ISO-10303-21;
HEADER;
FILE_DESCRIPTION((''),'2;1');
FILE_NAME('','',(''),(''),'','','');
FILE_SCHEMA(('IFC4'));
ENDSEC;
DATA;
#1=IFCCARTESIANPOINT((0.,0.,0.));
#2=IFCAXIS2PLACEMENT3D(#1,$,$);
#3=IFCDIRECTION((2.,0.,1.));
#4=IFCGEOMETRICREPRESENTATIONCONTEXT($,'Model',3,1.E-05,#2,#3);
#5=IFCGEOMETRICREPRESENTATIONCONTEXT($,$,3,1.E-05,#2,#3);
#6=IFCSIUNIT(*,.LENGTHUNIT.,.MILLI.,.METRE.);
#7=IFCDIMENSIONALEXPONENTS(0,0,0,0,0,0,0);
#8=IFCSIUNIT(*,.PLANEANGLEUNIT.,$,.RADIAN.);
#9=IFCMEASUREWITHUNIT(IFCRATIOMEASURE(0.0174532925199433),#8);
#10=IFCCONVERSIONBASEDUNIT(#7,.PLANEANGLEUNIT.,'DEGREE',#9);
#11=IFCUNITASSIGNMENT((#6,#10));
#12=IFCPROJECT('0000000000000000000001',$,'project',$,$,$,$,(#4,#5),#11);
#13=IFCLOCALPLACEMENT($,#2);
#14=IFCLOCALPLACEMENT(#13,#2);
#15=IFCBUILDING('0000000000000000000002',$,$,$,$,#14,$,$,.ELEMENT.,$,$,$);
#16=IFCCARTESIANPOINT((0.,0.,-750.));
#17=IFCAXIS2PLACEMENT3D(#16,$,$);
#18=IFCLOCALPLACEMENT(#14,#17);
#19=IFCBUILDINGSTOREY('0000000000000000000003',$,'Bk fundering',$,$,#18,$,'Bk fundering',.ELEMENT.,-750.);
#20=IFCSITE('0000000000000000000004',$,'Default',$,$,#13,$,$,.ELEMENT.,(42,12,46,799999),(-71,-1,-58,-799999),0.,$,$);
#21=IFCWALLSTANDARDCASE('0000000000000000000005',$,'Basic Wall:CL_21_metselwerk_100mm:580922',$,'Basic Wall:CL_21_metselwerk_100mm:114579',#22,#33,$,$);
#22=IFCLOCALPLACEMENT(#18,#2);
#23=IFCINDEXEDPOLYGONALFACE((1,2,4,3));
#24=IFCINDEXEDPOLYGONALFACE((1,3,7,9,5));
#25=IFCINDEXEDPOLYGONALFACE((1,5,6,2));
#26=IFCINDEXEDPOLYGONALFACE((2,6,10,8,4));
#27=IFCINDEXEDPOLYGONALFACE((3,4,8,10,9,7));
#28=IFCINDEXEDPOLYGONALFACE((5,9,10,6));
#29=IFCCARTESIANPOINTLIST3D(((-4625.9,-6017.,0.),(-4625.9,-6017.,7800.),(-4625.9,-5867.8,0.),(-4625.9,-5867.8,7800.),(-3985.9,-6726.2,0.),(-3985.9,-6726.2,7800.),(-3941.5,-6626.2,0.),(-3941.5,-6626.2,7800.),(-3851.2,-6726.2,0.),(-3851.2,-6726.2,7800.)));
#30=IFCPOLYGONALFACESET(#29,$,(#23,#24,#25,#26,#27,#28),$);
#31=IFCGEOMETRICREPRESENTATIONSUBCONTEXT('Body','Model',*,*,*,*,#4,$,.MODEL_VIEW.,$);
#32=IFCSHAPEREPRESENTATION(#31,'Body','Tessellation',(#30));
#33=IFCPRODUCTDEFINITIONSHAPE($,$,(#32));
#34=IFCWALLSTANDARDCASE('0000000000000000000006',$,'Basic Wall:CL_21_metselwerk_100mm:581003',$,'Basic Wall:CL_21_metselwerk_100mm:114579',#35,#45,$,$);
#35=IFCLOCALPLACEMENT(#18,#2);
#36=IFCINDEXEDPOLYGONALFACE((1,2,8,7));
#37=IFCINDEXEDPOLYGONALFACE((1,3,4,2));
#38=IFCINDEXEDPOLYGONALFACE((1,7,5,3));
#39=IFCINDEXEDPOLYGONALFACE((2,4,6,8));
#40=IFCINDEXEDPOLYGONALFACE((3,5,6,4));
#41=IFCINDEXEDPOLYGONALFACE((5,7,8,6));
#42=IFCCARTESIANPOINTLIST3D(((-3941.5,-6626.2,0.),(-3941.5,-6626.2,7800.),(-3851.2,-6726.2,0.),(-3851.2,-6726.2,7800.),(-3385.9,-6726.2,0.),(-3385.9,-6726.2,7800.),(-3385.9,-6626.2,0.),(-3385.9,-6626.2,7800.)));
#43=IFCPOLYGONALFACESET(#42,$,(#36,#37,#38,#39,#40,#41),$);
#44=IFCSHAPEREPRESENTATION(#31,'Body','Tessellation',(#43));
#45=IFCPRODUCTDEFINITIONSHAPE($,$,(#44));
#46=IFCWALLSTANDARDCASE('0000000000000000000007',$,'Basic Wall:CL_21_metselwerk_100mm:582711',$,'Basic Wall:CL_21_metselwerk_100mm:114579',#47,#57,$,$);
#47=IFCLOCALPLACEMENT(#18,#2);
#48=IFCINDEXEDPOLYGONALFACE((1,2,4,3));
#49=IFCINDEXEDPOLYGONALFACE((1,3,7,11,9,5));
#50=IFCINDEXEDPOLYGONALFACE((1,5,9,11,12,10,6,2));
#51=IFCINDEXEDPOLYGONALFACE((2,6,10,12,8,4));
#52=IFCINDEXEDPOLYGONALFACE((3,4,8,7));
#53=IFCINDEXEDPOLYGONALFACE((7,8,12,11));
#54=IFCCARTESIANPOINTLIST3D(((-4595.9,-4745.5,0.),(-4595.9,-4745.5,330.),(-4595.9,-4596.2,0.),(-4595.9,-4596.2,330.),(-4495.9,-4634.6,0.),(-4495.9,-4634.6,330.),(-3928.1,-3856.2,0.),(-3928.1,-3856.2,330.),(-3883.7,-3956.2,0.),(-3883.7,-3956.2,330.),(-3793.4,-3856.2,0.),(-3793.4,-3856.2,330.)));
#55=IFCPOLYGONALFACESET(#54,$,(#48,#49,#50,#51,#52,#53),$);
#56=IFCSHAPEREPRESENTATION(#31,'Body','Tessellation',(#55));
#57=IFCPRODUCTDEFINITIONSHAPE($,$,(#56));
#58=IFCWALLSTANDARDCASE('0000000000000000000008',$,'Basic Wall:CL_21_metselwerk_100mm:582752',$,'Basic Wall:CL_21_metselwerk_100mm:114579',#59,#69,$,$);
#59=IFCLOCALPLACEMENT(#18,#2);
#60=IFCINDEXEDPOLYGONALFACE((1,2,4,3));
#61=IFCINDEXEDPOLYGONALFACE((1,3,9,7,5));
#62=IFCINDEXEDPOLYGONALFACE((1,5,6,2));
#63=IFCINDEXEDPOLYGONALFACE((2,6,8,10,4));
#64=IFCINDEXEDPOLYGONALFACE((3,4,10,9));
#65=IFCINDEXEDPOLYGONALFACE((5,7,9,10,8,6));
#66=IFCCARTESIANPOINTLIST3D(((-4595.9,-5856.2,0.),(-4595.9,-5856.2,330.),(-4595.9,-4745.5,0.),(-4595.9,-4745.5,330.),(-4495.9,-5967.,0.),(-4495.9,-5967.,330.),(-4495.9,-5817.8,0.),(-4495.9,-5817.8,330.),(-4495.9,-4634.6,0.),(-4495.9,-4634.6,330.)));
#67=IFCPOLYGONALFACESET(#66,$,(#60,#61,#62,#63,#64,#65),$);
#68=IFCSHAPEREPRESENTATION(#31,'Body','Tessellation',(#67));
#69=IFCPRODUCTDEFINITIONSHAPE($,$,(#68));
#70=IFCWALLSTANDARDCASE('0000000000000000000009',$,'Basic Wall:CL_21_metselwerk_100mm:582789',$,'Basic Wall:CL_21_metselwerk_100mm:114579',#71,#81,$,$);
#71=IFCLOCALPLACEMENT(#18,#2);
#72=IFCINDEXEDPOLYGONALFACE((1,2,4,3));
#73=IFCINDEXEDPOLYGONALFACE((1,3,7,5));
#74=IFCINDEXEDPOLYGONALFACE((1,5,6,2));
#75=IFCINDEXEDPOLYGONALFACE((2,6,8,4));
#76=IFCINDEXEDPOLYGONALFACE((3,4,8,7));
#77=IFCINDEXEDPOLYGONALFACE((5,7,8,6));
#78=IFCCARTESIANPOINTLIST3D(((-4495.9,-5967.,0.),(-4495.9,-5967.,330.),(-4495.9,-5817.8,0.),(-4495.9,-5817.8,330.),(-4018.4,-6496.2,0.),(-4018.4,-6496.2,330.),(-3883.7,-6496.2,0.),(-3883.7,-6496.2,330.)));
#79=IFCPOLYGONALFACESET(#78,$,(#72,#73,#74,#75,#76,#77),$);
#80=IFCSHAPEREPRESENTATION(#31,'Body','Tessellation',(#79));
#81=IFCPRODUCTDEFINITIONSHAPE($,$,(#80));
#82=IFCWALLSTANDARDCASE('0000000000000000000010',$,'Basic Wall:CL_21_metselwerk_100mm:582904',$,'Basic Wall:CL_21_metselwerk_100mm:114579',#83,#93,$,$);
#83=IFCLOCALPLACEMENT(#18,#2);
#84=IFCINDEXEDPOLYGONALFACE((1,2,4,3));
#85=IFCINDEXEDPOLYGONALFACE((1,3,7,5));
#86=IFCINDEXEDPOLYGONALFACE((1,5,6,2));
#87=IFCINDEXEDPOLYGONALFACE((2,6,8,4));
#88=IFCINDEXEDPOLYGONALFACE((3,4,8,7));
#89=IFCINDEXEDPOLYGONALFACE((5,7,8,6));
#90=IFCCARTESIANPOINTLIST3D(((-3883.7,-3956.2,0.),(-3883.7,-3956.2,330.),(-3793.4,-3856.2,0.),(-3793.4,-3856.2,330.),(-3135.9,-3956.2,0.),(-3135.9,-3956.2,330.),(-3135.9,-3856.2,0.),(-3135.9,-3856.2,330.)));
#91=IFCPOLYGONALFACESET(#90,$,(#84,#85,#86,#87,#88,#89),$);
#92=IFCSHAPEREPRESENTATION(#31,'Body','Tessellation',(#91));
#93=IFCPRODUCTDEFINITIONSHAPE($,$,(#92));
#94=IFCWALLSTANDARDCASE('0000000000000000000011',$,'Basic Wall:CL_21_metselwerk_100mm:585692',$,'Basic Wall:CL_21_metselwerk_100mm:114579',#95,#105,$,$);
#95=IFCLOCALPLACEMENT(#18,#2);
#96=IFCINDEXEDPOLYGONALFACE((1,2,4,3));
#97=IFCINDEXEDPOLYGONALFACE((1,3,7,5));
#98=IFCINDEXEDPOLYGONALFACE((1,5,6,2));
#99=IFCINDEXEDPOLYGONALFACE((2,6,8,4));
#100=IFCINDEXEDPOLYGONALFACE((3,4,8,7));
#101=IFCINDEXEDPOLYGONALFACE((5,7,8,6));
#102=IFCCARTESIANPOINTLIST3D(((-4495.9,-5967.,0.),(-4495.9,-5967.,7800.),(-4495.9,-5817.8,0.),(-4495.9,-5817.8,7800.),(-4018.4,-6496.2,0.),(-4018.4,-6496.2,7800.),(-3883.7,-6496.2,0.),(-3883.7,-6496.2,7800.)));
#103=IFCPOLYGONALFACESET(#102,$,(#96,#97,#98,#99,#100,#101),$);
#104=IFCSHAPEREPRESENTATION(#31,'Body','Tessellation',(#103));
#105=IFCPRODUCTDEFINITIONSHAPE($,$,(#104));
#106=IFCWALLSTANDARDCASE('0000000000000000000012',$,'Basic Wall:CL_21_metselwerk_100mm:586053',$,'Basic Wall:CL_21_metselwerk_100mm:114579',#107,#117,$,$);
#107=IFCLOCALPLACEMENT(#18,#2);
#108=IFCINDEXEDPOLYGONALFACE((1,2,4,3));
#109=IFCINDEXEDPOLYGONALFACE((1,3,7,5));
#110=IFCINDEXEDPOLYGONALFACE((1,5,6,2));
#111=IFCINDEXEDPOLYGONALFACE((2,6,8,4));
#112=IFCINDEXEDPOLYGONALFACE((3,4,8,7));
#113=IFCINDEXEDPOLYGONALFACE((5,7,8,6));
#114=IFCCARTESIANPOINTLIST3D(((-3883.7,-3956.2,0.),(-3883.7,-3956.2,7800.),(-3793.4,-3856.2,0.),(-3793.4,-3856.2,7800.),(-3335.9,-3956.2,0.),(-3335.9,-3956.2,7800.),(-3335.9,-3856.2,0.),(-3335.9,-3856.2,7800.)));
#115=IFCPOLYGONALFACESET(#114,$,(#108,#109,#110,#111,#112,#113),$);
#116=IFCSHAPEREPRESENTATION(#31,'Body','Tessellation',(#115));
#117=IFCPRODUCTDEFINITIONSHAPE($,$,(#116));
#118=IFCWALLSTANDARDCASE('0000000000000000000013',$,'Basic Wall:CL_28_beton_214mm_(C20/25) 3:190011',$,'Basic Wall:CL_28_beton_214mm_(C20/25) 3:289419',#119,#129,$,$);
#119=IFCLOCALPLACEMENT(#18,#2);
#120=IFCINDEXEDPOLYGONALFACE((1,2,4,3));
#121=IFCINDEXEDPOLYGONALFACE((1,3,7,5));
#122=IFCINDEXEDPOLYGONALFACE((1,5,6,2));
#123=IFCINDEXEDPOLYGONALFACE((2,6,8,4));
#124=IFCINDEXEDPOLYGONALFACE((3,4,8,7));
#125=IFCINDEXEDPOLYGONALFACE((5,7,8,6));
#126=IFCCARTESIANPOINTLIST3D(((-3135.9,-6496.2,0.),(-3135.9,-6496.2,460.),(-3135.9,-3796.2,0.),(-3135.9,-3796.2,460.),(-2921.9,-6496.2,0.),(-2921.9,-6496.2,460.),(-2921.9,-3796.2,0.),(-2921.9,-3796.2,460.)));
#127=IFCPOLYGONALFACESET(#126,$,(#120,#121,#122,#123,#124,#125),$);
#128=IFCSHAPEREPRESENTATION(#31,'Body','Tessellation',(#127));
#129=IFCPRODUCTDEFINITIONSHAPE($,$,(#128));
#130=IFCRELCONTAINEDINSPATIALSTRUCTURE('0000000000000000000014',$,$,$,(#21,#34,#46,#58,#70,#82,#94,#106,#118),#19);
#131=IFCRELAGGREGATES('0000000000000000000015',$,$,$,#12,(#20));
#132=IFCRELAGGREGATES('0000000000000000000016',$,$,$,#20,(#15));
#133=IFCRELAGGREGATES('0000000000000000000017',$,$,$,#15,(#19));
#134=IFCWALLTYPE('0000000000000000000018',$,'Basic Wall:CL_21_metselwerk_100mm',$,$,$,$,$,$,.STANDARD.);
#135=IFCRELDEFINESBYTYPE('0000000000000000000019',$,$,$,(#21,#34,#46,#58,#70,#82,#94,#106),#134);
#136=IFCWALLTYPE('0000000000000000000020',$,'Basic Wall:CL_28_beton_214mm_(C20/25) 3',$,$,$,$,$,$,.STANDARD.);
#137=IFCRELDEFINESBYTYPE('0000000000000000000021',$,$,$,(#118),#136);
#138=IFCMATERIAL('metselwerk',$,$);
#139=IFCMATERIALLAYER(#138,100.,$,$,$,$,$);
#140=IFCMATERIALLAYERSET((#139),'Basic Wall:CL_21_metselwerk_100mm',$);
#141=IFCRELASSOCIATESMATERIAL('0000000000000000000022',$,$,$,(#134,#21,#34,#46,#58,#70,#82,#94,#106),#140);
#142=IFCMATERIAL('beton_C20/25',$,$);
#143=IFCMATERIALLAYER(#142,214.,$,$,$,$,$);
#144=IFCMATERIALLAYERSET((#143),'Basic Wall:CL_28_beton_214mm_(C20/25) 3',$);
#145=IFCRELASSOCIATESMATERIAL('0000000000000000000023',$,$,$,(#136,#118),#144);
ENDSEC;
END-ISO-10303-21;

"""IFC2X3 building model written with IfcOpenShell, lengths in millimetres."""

from ifc_helpers import new_model, entity, si_unit, converted_unit, direction, frame, frame_2d, origin, place, context, subcontext, project, spatial, polyline, rectangle, outline, extrude, clip, bounded_halfspace, material, layer, layer_set, layer_usage, type_object, element, save


model = new_model("IFC2X3")

# Units and contexts
model_context = context("Model", 3, precision=1e-05, world=origin(), true_north=direction((2.0, 0.0, 1.0)))
context_of_model = context(None, 3, precision=1e-05, world=origin(), true_north=direction((2.0, 0.0, 1.0)))
body_context = subcontext(model_context, "Body", "Model", "MODEL_VIEW")
ifc_project = project(units=[si_unit("LENGTHUNIT", "METRE", prefix="MILLI"), converted_unit("PLANEANGLEUNIT", "DEGREE", entity("IfcRatioMeasure", 0.0174532925199433), si_unit("PLANEANGLEUNIT", "RADIAN"), dimensions=[0, 0, 0, 0, 0, 0, 0])], contexts=[model_context, context_of_model])

# Site, building, storey
site_placement = place(None, origin())
site = spatial("IfcSite", under=ifc_project, at=site_placement, Name="Default", CompositionType="ELEMENT", RefLatitude=(42, 12, 46, 799999), RefLongitude=(-71, -1, -58, -799999), RefElevation=0.0)
building_placement = place(site_placement, origin())
building = spatial("IfcBuilding", under=site, at=building_placement, CompositionType="ELEMENT")
storey_placement = place(building_placement, frame((0.0, 0.0, -750.0)))
storey = spatial("IfcBuildingStorey", under=building, at=storey_placement, Name="Bk fundering", LongName="Bk fundering", CompositionType="ELEMENT", Elevation=-750.0)

# Walls
ifc_material_1 = material(Name="metselwerk")
ifc_layer_1 = layer(ifc_material_1, 100.0)
ifc_layer_set_1 = layer_set([ifc_layer_1], Name="Basic Wall:CL_21_metselwerk_100mm")
wall_type_1 = type_object("IfcWallType", Name="Basic Wall:CL_21_metselwerk_100mm", PredefinedType="STANDARD", material=ifc_layer_set_1)
ifc_layer_usage_1 = layer_usage(ifc_layer_set_1, "AXIS2", "NEGATIVE", 50.0)
wall_1_placement = place(storey_placement, frame((-4663.0, -5901.2, 0.0), z_axis=(0.0, 0.0, 1.0), x_axis=(0.669965, -0.742393, 0.0)))
element("IfcWallStandardCase", 1, at=wall_1_placement, inside=storey, type_object=wall_type_1, material=ifc_layer_usage_1, Name="Basic Wall:CL_21_metselwerk_100mm:580922", ObjectType="Basic Wall:CL_21_metselwerk_100mm:114579", context=body_context, shape_type="SweptSolid", body=[
    extrude(outline(polyline([(1066.1, -50.0), (1156.3, 50.0), (1021.6, 50.0), (0.0, 50.0), (110.8, -50.0), (1066.1, -50.0)])), origin(), (0.0, 0.0, 1.0), 7800.0),
])
ifc_layer_usage_2 = layer_usage(ifc_layer_set_1, "AXIS2", "POSITIVE", -50.0)
wall_2_placement = place(storey_placement, frame((-3941.5, -6676.2, 0.0)))
element("IfcWallStandardCase", 2, at=wall_2_placement, inside=storey, type_object=wall_type_1, material=ifc_layer_usage_2, Name="Basic Wall:CL_21_metselwerk_100mm:581003", ObjectType="Basic Wall:CL_21_metselwerk_100mm:114579", context=body_context, shape_type="SweptSolid", body=[
    extrude(outline(polyline([(555.6, -50.0), (555.6, 50.0), (0.0, 50.0), (90.2, -50.0), (555.6, -50.0)])), origin(), (0.0, 0.0, 1.0), 7800.0),
])
ifc_layer_usage_3 = layer_usage(ifc_layer_set_1, "AXIS2", "NEGATIVE", 50.0)
wall_3_placement = place(storey_placement, frame((-3830.5, -3822.7, 0.0), z_axis=(0.0, 0.0, 1.0), x_axis=(-0.669965, -0.742393, 0.0)))
element("IfcWallStandardCase", 3, at=wall_3_placement, inside=storey, type_object=wall_type_1, material=ifc_layer_usage_3, Name="Basic Wall:CL_21_metselwerk_100mm:582711", ObjectType="Basic Wall:CL_21_metselwerk_100mm:114579", context=body_context, shape_type="SweptSolid", body=[
    extrude(outline(polyline([(1087.0, -50.0), (1197.8, 50.0), (1048.6, 50.0), (134.7, 50.0), (0.0, 50.0), (90.2, -50.0), (1087.0, -50.0)])), origin(), (0.0, 0.0, 1.0), 330.0),
])
ifc_layer_usage_4 = layer_usage(ifc_layer_set_1, "AXIS2", "NEGATIVE", 50.0)
wall_4_placement = place(storey_placement, frame((-4545.9, -4634.6, 0.0), z_axis=(0.0, 0.0, 1.0), x_axis=(0.0, -1.0, 0.0)))
element("IfcWallStandardCase", 4, at=wall_4_placement, inside=storey, type_object=wall_type_1, material=ifc_layer_usage_4, Name="Basic Wall:CL_21_metselwerk_100mm:582752", ObjectType="Basic Wall:CL_21_metselwerk_100mm:114579", context=body_context, shape_type="SweptSolid", body=[
    extrude(outline(polyline([(1221.6, -50.0), (1332.4, 50.0), (1183.1, 50.0), (0.0, 50.0), (110.8, -50.0), (1221.6, -50.0)])), origin(), (0.0, 0.0, 1.0), 330.0),
])
ifc_layer_usage_5 = layer_usage(ifc_layer_set_1, "AXIS2", "NEGATIVE", 50.0)
wall_5_placement = place(storey_placement, frame((-4533.0, -5851.3, 0.0), z_axis=(0.0, 0.0, 1.0), x_axis=(0.669965, -0.742393, 0.0)))
element("IfcWallStandardCase", 5, at=wall_5_placement, inside=storey, type_object=wall_type_1, material=ifc_layer_usage_5, Name="Basic Wall:CL_21_metselwerk_100mm:582789", ObjectType="Basic Wall:CL_21_metselwerk_100mm:114579", context=body_context, shape_type="SweptSolid", body=[
    extrude(outline(polyline([(823.6, -50.0), (913.9, 50.0), (0.0, 50.0), (110.8, -50.0), (823.6, -50.0)])), origin(), (0.0, 0.0, 1.0), 330.0),
])
ifc_layer_usage_6 = layer_usage(ifc_layer_set_1, "AXIS2", "NEGATIVE", 50.0)
wall_6_placement = place(storey_placement, frame((-3135.9, -3906.2, 0.0), z_axis=(0.0, 0.0, 1.0), x_axis=(-1.0, 0.0, 0.0)))
element("IfcWallStandardCase", 6, at=wall_6_placement, inside=storey, type_object=wall_type_1, material=ifc_layer_usage_6, Name="Basic Wall:CL_21_metselwerk_100mm:582904", ObjectType="Basic Wall:CL_21_metselwerk_100mm:114579", context=body_context, shape_type="SweptSolid", body=[
    extrude(outline(polyline([(657.5, -50.0), (747.8, 50.0), (0.0, 50.0), (0.0, -50.0), (657.5, -50.0)])), origin(), (0.0, 0.0, 1.0), 330.0),
])

# Wall
ifc_layer_usage_7 = layer_usage(ifc_layer_set_1, "AXIS2", "NEGATIVE", 50.0)
wall_7_placement = place(storey_placement, frame((-4533.0, -5851.3, 0.0), z_axis=(0.0, 0.0, 1.0), x_axis=(0.669965, -0.742393, 0.0)))
element("IfcWallStandardCase", 7, at=wall_7_placement, inside=storey, type_object=wall_type_1, material=ifc_layer_usage_7, Name="Basic Wall:CL_21_metselwerk_100mm:585692", ObjectType="Basic Wall:CL_21_metselwerk_100mm:114579", context=body_context, shape_type="SweptSolid", body=[
    extrude(outline(polyline([(823.6, -50.0), (913.9, 50.0), (0.0, 50.0), (110.8, -50.0), (823.6, -50.0)])), origin(), (0.0, 0.0, 1.0), 7800.0),
])

# Walls
ifc_layer_usage_8 = layer_usage(ifc_layer_set_1, "AXIS2", "NEGATIVE", 50.0)
wall_8_placement = place(storey_placement, frame((-3335.9, -3906.2, 0.0), z_axis=(0.0, 0.0, 1.0), x_axis=(-1.0, 0.0, 0.0)))
element("IfcWallStandardCase", 8, at=wall_8_placement, inside=storey, type_object=wall_type_1, material=ifc_layer_usage_8, Name="Basic Wall:CL_21_metselwerk_100mm:586053", ObjectType="Basic Wall:CL_21_metselwerk_100mm:114579", context=body_context, shape_type="SweptSolid", body=[
    extrude(outline(polyline([(457.5, -50.0), (547.8, 50.0), (0.0, 50.0), (0.0, -50.0), (457.5, -50.0)])), origin(), (0.0, 0.0, 1.0), 7800.0),
])
ifc_material_2 = material(Name="beton_C20/25")
ifc_layer_2 = layer(ifc_material_2, 214.0)
ifc_layer_set_2 = layer_set([ifc_layer_2], Name="Basic Wall:CL_28_beton_214mm_(C20/25) 3")
ifc_layer_usage_9 = layer_usage(ifc_layer_set_2, "AXIS2", "NEGATIVE", 107.0)
wall_type_2 = type_object("IfcWallType", Name="Basic Wall:CL_28_beton_214mm_(C20/25) 3", PredefinedType="STANDARD", material=ifc_layer_set_2)
wall_9_placement = place(storey_placement, frame((-3028.9, -3796.2, 0.0), z_axis=(0.0, 0.0, 1.0), x_axis=(0.0, -1.0, 0.0)))
element("IfcWallStandardCase", 9, at=wall_9_placement, inside=storey, type_object=wall_type_2, material=ifc_layer_usage_9, Name="Basic Wall:CL_28_beton_214mm_(C20/25) 3:190011", ObjectType="Basic Wall:CL_28_beton_214mm_(C20/25) 3:289419", context=body_context, shape_type="Clipping", body=[
    clip(extrude(rectangle(XDim=2700.0, YDim=214.0, at=frame_2d((1350.0, 0.0), x_axis=(-1.0, 0.0))), origin(), (0.0, 0.0, 1.0), 460.0), bounded_halfspace(frame((0.0, -107.0, 460.0), z_axis=(0.0, 0.0, -1.0), x_axis=(1.0, 0.0, 0.0)), True, frame((0.0, -107.0, 460.0)), polyline([(0.0, 0.0), (60.0, 0.0), (2700.0, 0.0), (2700.0, 214.0), (0.0, 214.0), (0.0, 0.0)]))),
])

save(model, "model.ifc")
